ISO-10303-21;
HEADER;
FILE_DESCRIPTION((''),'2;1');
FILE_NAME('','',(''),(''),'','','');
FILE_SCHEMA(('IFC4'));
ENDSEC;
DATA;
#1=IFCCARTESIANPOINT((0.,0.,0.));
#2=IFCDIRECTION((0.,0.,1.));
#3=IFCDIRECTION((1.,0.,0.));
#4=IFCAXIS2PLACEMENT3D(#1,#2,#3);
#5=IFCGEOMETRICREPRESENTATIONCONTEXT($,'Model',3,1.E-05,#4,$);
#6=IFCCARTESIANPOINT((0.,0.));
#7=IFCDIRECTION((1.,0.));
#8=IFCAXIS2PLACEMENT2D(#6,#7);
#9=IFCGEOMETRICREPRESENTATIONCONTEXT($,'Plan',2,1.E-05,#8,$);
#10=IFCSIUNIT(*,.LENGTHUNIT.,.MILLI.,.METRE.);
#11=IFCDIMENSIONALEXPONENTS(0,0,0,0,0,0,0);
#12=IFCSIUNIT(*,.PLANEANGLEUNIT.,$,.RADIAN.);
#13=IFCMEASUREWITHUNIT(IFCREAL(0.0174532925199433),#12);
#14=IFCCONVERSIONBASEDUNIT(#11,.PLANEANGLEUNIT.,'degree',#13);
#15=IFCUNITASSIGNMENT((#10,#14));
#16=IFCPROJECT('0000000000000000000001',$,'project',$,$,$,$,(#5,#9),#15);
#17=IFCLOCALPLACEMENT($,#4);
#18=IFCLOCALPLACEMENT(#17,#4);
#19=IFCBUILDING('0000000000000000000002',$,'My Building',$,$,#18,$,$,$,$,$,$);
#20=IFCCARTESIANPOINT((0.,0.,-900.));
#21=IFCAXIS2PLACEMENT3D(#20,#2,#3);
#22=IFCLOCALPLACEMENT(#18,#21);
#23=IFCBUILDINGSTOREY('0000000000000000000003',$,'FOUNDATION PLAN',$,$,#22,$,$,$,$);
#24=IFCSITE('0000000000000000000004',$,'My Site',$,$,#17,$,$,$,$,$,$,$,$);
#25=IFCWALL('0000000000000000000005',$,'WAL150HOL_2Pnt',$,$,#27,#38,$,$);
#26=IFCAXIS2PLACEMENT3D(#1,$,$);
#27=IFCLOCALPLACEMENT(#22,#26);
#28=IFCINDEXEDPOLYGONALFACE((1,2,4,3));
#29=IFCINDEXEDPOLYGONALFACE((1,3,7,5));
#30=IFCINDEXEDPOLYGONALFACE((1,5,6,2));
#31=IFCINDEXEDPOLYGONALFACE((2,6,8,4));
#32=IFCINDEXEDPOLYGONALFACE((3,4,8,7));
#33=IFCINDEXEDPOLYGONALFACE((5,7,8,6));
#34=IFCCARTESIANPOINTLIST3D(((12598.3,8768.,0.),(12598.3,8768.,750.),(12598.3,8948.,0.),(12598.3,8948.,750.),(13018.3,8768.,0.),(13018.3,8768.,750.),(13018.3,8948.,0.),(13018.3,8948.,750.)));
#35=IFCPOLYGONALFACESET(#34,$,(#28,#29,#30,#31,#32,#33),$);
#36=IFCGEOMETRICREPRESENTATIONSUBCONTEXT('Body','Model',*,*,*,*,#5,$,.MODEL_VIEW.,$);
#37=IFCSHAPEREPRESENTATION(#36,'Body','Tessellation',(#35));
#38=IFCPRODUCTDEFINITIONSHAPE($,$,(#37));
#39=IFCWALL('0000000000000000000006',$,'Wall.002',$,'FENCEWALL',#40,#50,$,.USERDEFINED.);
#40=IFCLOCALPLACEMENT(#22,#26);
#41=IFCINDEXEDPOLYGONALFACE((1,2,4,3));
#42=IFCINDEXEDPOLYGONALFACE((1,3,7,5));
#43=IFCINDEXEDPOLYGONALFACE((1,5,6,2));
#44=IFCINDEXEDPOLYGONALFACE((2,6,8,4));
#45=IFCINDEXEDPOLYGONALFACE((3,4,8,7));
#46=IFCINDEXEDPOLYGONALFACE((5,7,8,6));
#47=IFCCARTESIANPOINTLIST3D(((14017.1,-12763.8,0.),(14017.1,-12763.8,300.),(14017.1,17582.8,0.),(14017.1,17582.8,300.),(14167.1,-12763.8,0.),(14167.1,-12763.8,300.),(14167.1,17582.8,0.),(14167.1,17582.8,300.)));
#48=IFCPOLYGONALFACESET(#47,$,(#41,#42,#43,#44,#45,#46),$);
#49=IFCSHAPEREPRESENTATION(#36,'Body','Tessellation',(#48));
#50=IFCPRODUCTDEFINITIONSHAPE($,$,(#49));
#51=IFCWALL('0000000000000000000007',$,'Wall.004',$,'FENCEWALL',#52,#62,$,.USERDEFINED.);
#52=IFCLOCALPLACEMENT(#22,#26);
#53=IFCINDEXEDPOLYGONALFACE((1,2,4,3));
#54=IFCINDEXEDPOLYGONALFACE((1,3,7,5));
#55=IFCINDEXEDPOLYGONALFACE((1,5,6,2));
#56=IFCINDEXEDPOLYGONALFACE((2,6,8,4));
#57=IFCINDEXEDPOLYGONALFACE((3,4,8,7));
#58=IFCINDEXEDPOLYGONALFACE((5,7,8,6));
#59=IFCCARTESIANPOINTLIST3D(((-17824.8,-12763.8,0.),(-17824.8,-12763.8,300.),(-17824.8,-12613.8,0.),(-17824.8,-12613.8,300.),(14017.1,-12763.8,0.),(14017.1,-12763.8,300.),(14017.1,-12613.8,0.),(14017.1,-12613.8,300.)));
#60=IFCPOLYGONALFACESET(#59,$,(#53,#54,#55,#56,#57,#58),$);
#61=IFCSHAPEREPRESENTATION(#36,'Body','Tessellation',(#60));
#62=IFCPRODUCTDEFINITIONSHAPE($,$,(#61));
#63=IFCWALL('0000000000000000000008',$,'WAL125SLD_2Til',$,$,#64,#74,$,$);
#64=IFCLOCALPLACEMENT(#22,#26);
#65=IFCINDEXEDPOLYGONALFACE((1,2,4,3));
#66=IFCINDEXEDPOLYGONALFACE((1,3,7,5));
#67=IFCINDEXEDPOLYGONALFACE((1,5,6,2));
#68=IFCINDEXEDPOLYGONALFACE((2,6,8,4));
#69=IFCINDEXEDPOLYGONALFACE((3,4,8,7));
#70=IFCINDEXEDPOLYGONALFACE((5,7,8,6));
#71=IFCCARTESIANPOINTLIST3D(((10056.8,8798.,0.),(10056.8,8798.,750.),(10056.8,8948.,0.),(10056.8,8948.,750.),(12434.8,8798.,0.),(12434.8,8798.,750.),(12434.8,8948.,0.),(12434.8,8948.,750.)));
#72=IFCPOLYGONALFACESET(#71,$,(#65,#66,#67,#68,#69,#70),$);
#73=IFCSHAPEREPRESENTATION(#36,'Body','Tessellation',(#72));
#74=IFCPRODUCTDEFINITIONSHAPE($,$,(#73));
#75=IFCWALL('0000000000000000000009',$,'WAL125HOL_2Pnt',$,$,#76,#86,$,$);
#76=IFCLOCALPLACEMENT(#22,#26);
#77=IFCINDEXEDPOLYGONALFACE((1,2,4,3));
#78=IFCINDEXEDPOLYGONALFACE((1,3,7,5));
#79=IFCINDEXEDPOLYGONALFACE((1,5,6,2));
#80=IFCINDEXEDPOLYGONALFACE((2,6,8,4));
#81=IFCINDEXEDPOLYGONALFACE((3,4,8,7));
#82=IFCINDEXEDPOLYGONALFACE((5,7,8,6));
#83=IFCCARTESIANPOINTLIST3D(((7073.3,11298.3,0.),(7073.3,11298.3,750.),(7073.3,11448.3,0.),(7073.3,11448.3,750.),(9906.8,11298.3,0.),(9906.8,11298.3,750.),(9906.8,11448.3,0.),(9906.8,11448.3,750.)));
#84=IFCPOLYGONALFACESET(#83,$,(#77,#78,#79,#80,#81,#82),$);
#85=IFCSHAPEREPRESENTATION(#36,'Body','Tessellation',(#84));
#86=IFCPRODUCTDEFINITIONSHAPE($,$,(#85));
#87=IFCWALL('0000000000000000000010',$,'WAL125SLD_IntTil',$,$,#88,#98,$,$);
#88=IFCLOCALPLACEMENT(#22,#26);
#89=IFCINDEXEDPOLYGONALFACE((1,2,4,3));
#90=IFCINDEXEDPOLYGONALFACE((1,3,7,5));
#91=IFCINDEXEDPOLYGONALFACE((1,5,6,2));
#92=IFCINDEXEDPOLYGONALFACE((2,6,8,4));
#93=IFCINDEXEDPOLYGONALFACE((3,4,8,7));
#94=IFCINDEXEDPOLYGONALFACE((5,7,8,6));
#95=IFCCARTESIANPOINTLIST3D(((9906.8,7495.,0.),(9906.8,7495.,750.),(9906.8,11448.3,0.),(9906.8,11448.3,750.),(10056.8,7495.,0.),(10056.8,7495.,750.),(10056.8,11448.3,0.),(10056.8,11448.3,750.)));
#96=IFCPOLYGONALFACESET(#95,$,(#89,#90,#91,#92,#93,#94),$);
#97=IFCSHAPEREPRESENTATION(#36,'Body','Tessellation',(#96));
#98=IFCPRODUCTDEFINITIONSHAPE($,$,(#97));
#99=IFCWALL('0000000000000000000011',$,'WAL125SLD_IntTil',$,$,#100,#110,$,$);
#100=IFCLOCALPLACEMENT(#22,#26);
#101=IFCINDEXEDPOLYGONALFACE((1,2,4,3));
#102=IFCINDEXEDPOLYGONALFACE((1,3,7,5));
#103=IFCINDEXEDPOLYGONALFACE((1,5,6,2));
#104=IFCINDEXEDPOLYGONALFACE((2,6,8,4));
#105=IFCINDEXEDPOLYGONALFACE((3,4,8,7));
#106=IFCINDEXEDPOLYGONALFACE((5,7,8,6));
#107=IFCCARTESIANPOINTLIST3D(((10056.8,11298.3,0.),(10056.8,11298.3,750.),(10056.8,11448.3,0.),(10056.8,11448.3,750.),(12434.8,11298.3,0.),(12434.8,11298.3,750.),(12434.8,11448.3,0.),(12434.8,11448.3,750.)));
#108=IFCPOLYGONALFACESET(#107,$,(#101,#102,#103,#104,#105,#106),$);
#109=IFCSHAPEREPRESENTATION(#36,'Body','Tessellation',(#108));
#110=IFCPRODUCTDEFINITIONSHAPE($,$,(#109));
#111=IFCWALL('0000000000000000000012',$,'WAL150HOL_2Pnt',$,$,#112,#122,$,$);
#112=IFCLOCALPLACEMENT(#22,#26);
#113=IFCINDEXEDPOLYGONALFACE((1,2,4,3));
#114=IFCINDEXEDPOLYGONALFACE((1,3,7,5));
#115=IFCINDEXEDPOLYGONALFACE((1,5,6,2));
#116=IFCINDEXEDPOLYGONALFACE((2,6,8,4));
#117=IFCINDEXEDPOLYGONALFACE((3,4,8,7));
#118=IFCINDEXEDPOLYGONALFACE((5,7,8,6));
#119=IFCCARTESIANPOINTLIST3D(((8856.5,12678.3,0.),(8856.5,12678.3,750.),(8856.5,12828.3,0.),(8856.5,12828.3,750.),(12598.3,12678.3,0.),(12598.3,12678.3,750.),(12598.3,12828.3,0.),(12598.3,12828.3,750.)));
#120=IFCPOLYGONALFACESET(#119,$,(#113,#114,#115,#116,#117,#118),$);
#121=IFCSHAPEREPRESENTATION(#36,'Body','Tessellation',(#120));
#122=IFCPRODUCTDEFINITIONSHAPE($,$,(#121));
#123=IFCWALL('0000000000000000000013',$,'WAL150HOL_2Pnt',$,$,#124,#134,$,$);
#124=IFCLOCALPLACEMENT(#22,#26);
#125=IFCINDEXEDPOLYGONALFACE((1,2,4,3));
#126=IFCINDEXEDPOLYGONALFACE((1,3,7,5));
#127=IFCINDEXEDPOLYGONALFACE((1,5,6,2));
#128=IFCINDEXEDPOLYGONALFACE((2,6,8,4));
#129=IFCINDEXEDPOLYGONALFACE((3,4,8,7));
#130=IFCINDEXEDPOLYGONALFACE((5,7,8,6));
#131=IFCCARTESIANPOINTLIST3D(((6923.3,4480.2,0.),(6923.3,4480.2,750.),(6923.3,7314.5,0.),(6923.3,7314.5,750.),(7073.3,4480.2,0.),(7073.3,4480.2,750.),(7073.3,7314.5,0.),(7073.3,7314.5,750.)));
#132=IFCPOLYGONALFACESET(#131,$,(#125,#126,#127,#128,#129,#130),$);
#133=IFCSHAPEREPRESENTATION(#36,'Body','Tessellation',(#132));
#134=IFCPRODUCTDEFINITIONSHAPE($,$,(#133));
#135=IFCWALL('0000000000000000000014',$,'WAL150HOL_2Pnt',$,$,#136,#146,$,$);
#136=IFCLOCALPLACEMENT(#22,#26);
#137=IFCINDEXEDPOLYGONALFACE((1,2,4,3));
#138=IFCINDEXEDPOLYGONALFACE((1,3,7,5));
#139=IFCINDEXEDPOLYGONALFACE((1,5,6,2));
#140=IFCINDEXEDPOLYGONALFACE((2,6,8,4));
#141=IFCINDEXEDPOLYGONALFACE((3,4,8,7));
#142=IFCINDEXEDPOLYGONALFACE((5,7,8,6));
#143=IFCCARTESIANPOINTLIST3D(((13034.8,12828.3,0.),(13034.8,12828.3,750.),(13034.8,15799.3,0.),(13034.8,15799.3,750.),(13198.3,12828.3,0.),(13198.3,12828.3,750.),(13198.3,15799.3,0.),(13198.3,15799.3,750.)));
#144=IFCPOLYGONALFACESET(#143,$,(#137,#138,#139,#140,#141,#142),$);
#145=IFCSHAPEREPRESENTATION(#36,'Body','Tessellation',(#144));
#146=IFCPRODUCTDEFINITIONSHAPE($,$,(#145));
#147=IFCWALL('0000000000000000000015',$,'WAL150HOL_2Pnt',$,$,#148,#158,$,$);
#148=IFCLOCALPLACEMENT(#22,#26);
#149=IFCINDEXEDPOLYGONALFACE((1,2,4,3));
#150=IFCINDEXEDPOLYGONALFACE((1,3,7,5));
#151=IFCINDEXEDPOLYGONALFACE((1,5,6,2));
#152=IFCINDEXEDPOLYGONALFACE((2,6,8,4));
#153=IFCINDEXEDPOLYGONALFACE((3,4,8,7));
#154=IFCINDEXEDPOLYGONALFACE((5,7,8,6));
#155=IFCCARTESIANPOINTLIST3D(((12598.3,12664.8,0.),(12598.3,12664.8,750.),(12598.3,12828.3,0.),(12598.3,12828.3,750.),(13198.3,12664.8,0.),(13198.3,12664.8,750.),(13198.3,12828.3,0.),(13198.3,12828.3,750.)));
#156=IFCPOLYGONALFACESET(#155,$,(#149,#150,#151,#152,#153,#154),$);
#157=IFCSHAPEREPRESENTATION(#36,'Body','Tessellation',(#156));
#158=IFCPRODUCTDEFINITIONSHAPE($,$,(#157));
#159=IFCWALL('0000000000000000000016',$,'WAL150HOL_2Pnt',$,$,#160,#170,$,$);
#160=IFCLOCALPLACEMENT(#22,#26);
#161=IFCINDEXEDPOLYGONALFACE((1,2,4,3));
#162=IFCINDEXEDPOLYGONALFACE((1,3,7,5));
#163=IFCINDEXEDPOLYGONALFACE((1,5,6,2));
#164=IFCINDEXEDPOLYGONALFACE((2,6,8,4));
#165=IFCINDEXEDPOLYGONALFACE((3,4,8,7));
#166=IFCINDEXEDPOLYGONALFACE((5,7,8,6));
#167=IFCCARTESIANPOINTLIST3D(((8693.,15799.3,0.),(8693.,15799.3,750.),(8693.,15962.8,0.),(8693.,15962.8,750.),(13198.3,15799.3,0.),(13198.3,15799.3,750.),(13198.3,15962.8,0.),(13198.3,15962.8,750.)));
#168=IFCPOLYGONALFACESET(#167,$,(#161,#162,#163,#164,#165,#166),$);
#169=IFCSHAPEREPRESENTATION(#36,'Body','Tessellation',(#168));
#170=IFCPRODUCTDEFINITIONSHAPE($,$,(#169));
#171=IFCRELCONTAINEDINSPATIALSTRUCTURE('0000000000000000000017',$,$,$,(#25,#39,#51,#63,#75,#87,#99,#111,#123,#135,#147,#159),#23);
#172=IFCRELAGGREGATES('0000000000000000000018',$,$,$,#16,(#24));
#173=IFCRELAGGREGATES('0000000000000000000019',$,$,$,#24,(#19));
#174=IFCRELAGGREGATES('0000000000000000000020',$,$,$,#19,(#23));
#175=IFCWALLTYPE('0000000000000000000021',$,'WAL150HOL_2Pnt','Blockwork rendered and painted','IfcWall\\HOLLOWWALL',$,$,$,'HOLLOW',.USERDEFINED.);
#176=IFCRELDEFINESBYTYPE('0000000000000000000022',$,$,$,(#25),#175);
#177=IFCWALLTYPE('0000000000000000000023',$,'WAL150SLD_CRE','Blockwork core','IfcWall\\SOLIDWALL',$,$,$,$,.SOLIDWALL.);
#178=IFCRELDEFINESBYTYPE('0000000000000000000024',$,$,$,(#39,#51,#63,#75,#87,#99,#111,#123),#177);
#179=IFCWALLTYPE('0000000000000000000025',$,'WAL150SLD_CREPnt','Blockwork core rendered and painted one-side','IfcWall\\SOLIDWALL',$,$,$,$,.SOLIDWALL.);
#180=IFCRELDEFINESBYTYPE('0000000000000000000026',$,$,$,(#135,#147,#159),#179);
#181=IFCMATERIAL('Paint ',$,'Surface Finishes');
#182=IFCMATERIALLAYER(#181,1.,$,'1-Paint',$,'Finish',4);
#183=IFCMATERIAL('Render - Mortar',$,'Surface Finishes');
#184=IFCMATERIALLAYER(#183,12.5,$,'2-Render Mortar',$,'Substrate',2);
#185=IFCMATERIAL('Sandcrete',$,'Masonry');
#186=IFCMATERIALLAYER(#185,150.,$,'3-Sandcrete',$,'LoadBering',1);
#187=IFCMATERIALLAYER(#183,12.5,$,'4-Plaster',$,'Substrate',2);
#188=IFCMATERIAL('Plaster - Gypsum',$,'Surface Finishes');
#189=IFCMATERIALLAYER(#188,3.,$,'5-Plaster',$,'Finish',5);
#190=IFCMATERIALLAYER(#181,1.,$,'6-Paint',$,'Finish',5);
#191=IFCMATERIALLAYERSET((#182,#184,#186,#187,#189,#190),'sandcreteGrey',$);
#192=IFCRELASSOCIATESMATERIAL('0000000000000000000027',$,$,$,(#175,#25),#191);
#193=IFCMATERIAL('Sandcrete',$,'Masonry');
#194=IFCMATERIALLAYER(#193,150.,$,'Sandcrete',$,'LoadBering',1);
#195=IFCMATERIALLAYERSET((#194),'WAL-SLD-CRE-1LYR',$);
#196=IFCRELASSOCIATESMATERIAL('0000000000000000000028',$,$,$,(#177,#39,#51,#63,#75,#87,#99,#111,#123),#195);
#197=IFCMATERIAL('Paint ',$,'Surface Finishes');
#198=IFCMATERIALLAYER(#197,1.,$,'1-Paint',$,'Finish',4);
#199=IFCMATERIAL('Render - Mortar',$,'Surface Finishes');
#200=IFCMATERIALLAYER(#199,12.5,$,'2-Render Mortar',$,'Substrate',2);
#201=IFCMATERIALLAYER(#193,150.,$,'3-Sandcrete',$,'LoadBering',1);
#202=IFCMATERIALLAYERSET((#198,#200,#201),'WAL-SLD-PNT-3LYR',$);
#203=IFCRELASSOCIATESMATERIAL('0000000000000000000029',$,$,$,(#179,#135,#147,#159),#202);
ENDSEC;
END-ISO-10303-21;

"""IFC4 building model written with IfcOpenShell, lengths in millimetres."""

from ifc_helpers import new_model, entity, si_unit, converted_unit, frame, origin_with_axes, origin_2d_with_axis, place, context, subcontext, project, spatial, indexed_curve, outline, extrude, material, layer, layer_set, layer_usage, type_object, element, save


model = new_model("IFC4")

# Units and contexts
model_context = context("Model", 3, precision=1e-05, world=origin_with_axes())
plan_context = context("Plan", 2, precision=1e-05, world=origin_2d_with_axis())
body_context = subcontext(model_context, "Body", "Model", "MODEL_VIEW")
ifc_project = project(units=[si_unit("LENGTHUNIT", "METRE", prefix="MILLI"), converted_unit("PLANEANGLEUNIT", "degree", entity("IfcReal", 0.0174532925199433), si_unit("PLANEANGLEUNIT", "RADIAN"), dimensions=[0, 0, 0, 0, 0, 0, 0])], contexts=[model_context, plan_context])

# Site, building, storey
site_placement = place(None, origin_with_axes())
site = spatial("IfcSite", under=ifc_project, at=site_placement, Name="My Site")
building_placement = place(site_placement, origin_with_axes())
building = spatial("IfcBuilding", under=site, at=building_placement, Name="My Building")
storey_placement = place(building_placement, frame((0.0, 0.0, -900.0), z_axis=(0.0, 0.0, 1.0), x_axis=(1.0, 0.0, 0.0)))
storey = spatial("IfcBuildingStorey", under=building, at=storey_placement, Name="FOUNDATION PLAN")

# Walls
ifc_material_1 = material(Name="Paint ", Category="Surface Finishes")
ifc_layer_1 = layer(ifc_material_1, 1.0, Name="1-Paint", Category="Finish", Priority=4)
ifc_material_2 = material(Name="Render - Mortar", Category="Surface Finishes")
ifc_layer_2 = layer(ifc_material_2, 12.5, Name="2-Render Mortar", Category="Substrate", Priority=2)
ifc_material_3 = material(Name="Sandcrete", Category="Masonry")
ifc_layer_3 = layer(ifc_material_3, 150.0, Name="3-Sandcrete", Category="LoadBering", Priority=1)
ifc_layer_4 = layer(ifc_material_2, 12.5, Name="4-Plaster", Category="Substrate", Priority=2)
ifc_material_4 = material(Name="Plaster - Gypsum", Category="Surface Finishes")
ifc_layer_5 = layer(ifc_material_4, 3.0, Name="5-Plaster", Category="Finish", Priority=5)
ifc_layer_6 = layer(ifc_material_1, 1.0, Name="6-Paint", Category="Finish", Priority=5)
ifc_layer_set_1 = layer_set([ifc_layer_1, ifc_layer_2, ifc_layer_3, ifc_layer_4, ifc_layer_5, ifc_layer_6], Name="sandcreteGrey")
ifc_layer_usage_1 = layer_usage(ifc_layer_set_1, "AXIS2", "POSITIVE", 0.0)
wall_type_1 = type_object("IfcWallType", Name="WAL150HOL_2Pnt", Description="Blockwork rendered and painted", ApplicableOccurrence="IfcWall\\HOLLOWWALL", ElementType="HOLLOW", PredefinedType="USERDEFINED", material=ifc_layer_set_1)
wall_1_placement = place(storey_placement, frame((13018.3, 8948.0, 0.0), z_axis=(0.0, 0.0, 1.0), x_axis=(-1.0, 0.000001, 0.0)))
element("IfcWall", 1, at=wall_1_placement, inside=storey, type_object=wall_type_1, material=ifc_layer_usage_1, Name="WAL150HOL_2Pnt", context=body_context, shape_type="SweptSolid", body=[
    extrude(outline(indexed_curve([(0.0, 0.0), (0.0, 180.0), (420.0, 180.0), (420.0, 0.0), (0.0, 0.0)], self_intersect=False)), origin_with_axes(), (0.0, 0.0, 1.0), 750.0),
])
ifc_material_5 = material(Name="Sandcrete", Category="Masonry")
ifc_layer_7 = layer(ifc_material_5, 150.0, Name="Sandcrete", Category="LoadBering", Priority=1)
ifc_layer_set_2 = layer_set([ifc_layer_7], Name="WAL-SLD-CRE-1LYR")
ifc_layer_usage_2 = layer_usage(ifc_layer_set_2, "AXIS2", "POSITIVE", 0.0)
wall_type_2 = type_object("IfcWallType", Name="WAL150SLD_CRE", Description="Blockwork core", ApplicableOccurrence="IfcWall\\SOLIDWALL", PredefinedType="SOLIDWALL", material=ifc_layer_set_2)
wall_2_placement = place(storey_placement, frame((14017.1, 17582.8, 0.0), z_axis=(0.0, 0.0, 1.0), x_axis=(-0.000001, -1.0, 0.0)))
element("IfcWall", 2, at=wall_2_placement, inside=storey, type_object=wall_type_2, material=ifc_layer_usage_2, Name="Wall.002", ObjectType="FENCEWALL", PredefinedType="USERDEFINED", context=body_context, shape_type="SweptSolid", body=[
    extrude(outline(indexed_curve([(0.0, 0.0), (0.0, 150.0), (30346.6, 150.0), (30346.6, 0.0), (0.0, 0.0)], self_intersect=False)), origin_with_axes(), (0.0, 0.0, 1.0), 300.0),
])
ifc_layer_usage_3 = layer_usage(ifc_layer_set_2, "AXIS2", "POSITIVE", 0.0)
wall_3_placement = place(storey_placement, frame((14017.1, -12613.8, 0.0), z_axis=(0.0, 0.0, 1.0), x_axis=(-1.0, 0.0, 0.0)))
element("IfcWall", 3, at=wall_3_placement, inside=storey, type_object=wall_type_2, material=ifc_layer_usage_3, Name="Wall.004", ObjectType="FENCEWALL", PredefinedType="USERDEFINED", context=body_context, shape_type="SweptSolid", body=[
    extrude(outline(indexed_curve([(0.0, 0.0), (0.0, 150.0), (31841.9, 150.0), (31841.9, 0.0), (0.0, 0.0)], self_intersect=False)), origin_with_axes(), (0.0, 0.0, 1.0), 300.0),
])
ifc_layer_usage_4 = layer_usage(ifc_layer_set_2, "AXIS2", "POSITIVE", 0.0)
wall_4_placement = place(storey_placement, frame((10056.8, 8798.0, 0.0), z_axis=(0.0, 0.0, 1.0), x_axis=(1.0, -0.000001, 0.0)))
element("IfcWall", 4, at=wall_4_placement, inside=storey, type_object=wall_type_2, material=ifc_layer_usage_4, Name="WAL125SLD_2Til", context=body_context, shape_type="SweptSolid", body=[
    extrude(outline(indexed_curve([(0.0, 0.0), (0.0, 150.0), (2378.0, 150.0), (2378.0, 0.0), (0.0, 0.0)], self_intersect=False)), origin_with_axes(), (0.0, 0.0, 1.0), 750.0),
])
ifc_layer_usage_5 = layer_usage(ifc_layer_set_2, "AXIS2", "POSITIVE", 0.0)
wall_5_placement = place(storey_placement, frame((7073.3, 11298.3, 0.0), z_axis=(0.0, 0.0, 1.0), x_axis=(1.0, -0.000002, 0.0)))
element("IfcWall", 5, at=wall_5_placement, inside=storey, type_object=wall_type_2, material=ifc_layer_usage_5, Name="WAL125HOL_2Pnt", context=body_context, shape_type="SweptSolid", body=[
    extrude(outline(indexed_curve([(0.0, 0.0), (0.0, 150.0), (2833.5, 150.0), (2833.5, 0.0), (0.0, 0.0)], self_intersect=False)), origin_with_axes(), (0.0, 0.0, 1.0), 750.0),
])
ifc_layer_usage_6 = layer_usage(ifc_layer_set_2, "AXIS2", "POSITIVE", 0.0)
wall_6_placement = place(storey_placement, frame((9906.8, 11448.3, 0.0), z_axis=(0.0, 0.0, 1.0), x_axis=(-0.000001, -1.0, 0.0)))
element("IfcWall", 6, at=wall_6_placement, inside=storey, type_object=wall_type_2, material=ifc_layer_usage_6, Name="WAL125SLD_IntTil", context=body_context, shape_type="SweptSolid", body=[
    extrude(outline(indexed_curve([(0.0, 0.0), (0.0, 150.0), (3953.3, 150.0), (3953.3, 0.0), (0.0, 0.0)], self_intersect=False)), origin_with_axes(), (0.0, 0.0, 1.0), 750.0),
])
ifc_layer_usage_7 = layer_usage(ifc_layer_set_2, "AXIS2", "POSITIVE", 0.0)
wall_7_placement = place(storey_placement, frame((10056.8, 11298.3, 0.0), z_axis=(0.0, 0.0, 1.0), x_axis=(1.0, -0.000001, 0.0)))
element("IfcWall", 7, at=wall_7_placement, inside=storey, type_object=wall_type_2, material=ifc_layer_usage_7, Name="WAL125SLD_IntTil", context=body_context, shape_type="SweptSolid", body=[
    extrude(outline(indexed_curve([(0.0, 0.0), (0.0, 150.0), (2378.0, 150.0), (2378.0, 0.0), (0.0, 0.0)], self_intersect=False)), origin_with_axes(), (0.0, 0.0, 1.0), 750.0),
])
ifc_layer_usage_8 = layer_usage(ifc_layer_set_2, "AXIS2", "POSITIVE", 0.0)
wall_8_placement = place(storey_placement, frame((12598.3, 12828.3, 0.0), z_axis=(0.0, 0.0, 1.0), x_axis=(-1.0, 0.000001, 0.0)))
element("IfcWall", 8, at=wall_8_placement, inside=storey, type_object=wall_type_2, material=ifc_layer_usage_8, Name="WAL150HOL_2Pnt", context=body_context, shape_type="SweptSolid", body=[
    extrude(outline(indexed_curve([(0.0, 0.0), (0.0, 150.0), (3741.8, 150.0), (3741.8, 0.0), (0.0, 0.0)], self_intersect=False)), origin_with_axes(), (0.0, 0.0, 1.0), 750.0),
])
ifc_layer_usage_9 = layer_usage(ifc_layer_set_2, "AXIS2", "POSITIVE", 0.0)
wall_9_placement = place(storey_placement, frame((7073.3, 4480.2, 0.0), z_axis=(0.0, 0.0, 1.0), x_axis=(0.000002, 1.0, 0.0)))
element("IfcWall", 9, at=wall_9_placement, inside=storey, type_object=wall_type_2, material=ifc_layer_usage_9, Name="WAL150HOL_2Pnt", context=body_context, shape_type="SweptSolid", body=[
    extrude(outline(indexed_curve([(0.0, 0.0), (0.0, 150.0), (2834.3, 150.0), (2834.3, 0.0), (0.0, 0.0)], self_intersect=False)), origin_with_axes(), (0.0, 0.0, 1.0), 750.0),
])
ifc_material_6 = material(Name="Paint ", Category="Surface Finishes")
ifc_layer_8 = layer(ifc_material_6, 1.0, Name="1-Paint", Category="Finish", Priority=4)
ifc_material_7 = material(Name="Render - Mortar", Category="Surface Finishes")
ifc_layer_9 = layer(ifc_material_7, 12.5, Name="2-Render Mortar", Category="Substrate", Priority=2)
ifc_layer_10 = layer(ifc_material_5, 150.0, Name="3-Sandcrete", Category="LoadBering", Priority=1)
ifc_layer_set_3 = layer_set([ifc_layer_8, ifc_layer_9, ifc_layer_10], Name="WAL-SLD-PNT-3LYR")
ifc_layer_usage_10 = layer_usage(ifc_layer_set_3, "AXIS2", "POSITIVE", 0.0)
wall_type_3 = type_object("IfcWallType", Name="WAL150SLD_CREPnt", Description="Blockwork core rendered and painted one-side", ApplicableOccurrence="IfcWall\\SOLIDWALL", PredefinedType="SOLIDWALL", material=ifc_layer_set_3)
wall_10_placement = place(storey_placement, frame((13198.3, 12828.3, 0.0), z_axis=(0.0, 0.0, 1.0), x_axis=(0.000001, 1.0, 0.0)))
element("IfcWall", 10, at=wall_10_placement, inside=storey, type_object=wall_type_3, material=ifc_layer_usage_10, Name="WAL150HOL_2Pnt", context=body_context, shape_type="SweptSolid", body=[
    extrude(outline(indexed_curve([(0.0, 0.0), (0.0, 163.5), (2971.0, 163.5), (2971.0, 0.0), (0.0, 0.0)], self_intersect=False)), origin_with_axes(), (0.0, 0.0, 1.0), 750.0),
])
ifc_layer_usage_11 = layer_usage(ifc_layer_set_3, "AXIS2", "POSITIVE", 0.0)
wall_11_placement = place(storey_placement, frame((12598.3, 12664.8, 0.0), z_axis=(0.0, 0.0, 1.0), x_axis=(1.0, -0.000001, 0.0)))
element("IfcWall", 11, at=wall_11_placement, inside=storey, type_object=wall_type_3, material=ifc_layer_usage_11, Name="WAL150HOL_2Pnt", context=body_context, shape_type="SweptSolid", body=[
    extrude(outline(indexed_curve([(0.0, 0.0), (0.0, 163.5), (600.0, 163.5), (600.0, 0.0), (0.0, 0.0)], self_intersect=False)), origin_with_axes(), (0.0, 0.0, 1.0), 750.0),
])
ifc_layer_usage_12 = layer_usage(ifc_layer_set_3, "AXIS2", "POSITIVE", 0.0)
wall_12_placement = place(storey_placement, frame((13198.3, 15962.8, 0.0), z_axis=(0.0, 0.0, 1.0), x_axis=(-1.0, 0.000001, 0.0)))
element("IfcWall", 12, at=wall_12_placement, inside=storey, type_object=wall_type_3, material=ifc_layer_usage_12, Name="WAL150HOL_2Pnt", context=body_context, shape_type="SweptSolid", body=[
    extrude(outline(indexed_curve([(0.0, 0.0), (0.0, 163.5), (4505.3, 163.5), (4505.3, 0.0), (0.0, 0.0)], self_intersect=False)), origin_with_axes(), (0.0, 0.0, 1.0), 750.0),
])

save(model, "model.ifc")
